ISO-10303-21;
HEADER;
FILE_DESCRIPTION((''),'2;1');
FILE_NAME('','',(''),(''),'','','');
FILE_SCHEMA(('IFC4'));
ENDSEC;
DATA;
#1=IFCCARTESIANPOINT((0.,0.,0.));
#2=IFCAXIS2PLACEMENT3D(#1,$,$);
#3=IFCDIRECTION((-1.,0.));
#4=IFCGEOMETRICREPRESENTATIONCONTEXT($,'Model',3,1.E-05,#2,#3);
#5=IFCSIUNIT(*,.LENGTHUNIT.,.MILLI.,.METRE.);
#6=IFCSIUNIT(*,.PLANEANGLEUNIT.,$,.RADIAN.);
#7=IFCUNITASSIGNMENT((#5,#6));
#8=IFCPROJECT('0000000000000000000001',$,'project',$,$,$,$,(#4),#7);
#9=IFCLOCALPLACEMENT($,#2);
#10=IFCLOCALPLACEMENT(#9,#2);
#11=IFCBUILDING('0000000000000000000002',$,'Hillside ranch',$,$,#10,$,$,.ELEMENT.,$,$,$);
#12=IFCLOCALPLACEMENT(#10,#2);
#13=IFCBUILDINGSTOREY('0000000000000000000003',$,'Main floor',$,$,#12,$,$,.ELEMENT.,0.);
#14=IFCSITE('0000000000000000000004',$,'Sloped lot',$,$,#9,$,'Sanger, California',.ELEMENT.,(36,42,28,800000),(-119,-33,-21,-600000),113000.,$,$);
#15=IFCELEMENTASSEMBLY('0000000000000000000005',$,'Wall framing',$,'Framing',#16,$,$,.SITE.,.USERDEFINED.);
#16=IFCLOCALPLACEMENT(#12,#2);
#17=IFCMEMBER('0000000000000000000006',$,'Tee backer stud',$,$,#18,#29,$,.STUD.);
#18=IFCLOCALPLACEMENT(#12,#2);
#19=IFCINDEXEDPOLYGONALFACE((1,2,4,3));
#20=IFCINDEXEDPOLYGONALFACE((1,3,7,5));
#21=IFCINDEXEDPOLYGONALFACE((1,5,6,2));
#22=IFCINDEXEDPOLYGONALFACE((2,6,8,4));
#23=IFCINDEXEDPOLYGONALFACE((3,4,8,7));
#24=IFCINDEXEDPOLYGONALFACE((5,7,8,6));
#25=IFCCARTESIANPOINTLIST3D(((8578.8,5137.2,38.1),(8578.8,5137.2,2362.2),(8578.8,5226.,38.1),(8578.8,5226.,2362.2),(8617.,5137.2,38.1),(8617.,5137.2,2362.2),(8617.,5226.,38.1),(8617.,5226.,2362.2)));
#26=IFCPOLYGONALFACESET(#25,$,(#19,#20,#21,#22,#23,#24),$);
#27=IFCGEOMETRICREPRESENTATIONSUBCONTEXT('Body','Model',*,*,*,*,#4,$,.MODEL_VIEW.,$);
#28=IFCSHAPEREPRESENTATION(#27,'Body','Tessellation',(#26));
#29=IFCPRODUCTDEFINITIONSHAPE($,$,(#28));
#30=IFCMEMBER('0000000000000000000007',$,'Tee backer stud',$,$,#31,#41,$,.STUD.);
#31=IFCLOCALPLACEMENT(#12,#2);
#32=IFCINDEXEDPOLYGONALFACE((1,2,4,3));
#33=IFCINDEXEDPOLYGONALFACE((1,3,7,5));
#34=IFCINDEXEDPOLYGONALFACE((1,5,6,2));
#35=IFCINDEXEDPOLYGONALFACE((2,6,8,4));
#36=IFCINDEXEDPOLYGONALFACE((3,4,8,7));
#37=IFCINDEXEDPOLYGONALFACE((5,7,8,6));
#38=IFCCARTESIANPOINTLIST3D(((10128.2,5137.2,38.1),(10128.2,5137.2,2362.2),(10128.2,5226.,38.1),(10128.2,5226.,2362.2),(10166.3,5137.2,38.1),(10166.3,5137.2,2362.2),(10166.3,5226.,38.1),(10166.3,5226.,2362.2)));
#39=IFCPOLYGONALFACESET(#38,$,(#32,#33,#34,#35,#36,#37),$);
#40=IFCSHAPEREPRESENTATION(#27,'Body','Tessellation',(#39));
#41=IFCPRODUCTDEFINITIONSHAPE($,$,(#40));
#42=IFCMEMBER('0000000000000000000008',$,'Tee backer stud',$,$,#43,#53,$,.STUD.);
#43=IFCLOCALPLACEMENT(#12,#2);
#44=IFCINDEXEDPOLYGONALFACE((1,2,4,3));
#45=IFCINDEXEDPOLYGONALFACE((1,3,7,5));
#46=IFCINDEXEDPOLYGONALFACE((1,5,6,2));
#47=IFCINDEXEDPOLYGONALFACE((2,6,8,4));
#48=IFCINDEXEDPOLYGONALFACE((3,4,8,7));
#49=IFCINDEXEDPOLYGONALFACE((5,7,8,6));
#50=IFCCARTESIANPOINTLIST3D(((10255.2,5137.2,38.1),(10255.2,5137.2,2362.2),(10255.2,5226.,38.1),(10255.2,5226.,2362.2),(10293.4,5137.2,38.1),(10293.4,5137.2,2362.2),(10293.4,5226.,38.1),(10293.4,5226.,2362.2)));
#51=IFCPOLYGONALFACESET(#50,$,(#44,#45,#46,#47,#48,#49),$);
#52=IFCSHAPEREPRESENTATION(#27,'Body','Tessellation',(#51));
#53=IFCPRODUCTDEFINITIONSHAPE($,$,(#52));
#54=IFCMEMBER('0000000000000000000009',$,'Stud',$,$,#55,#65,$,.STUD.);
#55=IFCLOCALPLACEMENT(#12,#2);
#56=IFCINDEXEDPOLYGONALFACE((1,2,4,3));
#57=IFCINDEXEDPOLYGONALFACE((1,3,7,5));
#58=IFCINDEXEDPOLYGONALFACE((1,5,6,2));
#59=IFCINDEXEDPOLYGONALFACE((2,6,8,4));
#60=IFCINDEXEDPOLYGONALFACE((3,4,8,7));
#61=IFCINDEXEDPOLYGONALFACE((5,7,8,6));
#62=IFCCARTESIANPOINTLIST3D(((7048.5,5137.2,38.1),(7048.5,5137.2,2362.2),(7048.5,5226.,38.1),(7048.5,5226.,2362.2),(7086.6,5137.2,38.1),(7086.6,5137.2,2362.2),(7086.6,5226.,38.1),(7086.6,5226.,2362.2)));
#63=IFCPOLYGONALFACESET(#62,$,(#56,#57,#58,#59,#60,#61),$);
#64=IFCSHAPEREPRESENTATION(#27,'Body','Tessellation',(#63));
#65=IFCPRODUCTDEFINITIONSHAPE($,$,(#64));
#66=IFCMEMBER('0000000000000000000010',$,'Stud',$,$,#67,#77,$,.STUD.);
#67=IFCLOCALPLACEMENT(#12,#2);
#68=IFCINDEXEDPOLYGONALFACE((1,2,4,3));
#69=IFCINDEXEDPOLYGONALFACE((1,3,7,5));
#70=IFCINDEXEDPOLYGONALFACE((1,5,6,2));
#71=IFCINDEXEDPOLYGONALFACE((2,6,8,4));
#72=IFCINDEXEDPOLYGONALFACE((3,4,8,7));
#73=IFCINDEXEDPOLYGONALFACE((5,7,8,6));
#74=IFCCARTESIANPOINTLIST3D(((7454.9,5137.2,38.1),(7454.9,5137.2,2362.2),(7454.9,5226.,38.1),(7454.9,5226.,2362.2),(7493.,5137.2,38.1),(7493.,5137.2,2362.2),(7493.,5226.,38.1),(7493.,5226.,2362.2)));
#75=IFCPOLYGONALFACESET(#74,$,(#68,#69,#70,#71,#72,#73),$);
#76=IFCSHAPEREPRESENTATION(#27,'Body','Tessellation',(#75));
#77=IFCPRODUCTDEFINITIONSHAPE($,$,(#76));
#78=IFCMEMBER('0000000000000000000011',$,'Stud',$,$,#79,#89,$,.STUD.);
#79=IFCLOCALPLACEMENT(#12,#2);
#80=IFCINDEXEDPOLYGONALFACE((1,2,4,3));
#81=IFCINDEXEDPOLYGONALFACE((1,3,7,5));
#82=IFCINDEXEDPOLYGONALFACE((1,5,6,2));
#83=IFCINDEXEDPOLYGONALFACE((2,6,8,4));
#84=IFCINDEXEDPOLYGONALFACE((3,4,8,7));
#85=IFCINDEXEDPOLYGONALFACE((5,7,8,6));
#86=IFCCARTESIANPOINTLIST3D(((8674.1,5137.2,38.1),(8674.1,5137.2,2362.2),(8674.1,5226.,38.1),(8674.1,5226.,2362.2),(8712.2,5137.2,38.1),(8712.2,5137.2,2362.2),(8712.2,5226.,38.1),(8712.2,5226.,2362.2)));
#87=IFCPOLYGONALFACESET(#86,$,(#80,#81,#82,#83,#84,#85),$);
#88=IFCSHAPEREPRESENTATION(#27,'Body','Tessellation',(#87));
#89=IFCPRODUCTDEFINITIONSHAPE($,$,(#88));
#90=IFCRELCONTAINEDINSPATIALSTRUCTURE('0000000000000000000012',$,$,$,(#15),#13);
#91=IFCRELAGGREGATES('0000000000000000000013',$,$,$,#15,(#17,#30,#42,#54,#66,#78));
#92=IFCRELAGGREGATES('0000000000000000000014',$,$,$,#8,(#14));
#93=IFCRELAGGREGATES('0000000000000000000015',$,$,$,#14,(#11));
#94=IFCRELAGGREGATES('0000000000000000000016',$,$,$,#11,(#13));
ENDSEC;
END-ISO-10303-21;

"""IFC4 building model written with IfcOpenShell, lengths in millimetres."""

from ifc_helpers import new_model, si_unit, direction, frame, origin, origin_with_axes, place, context, subcontext, project, spatial, polyline, outline, extrude, element, aggregate, save


model = new_model("IFC4")

# Units and contexts
model_context = context("Model", 3, precision=1e-05, world=origin(), true_north=direction((-1.0, 0.0)))
body_context = subcontext(model_context, "Body", "Model", "MODEL_VIEW")
ifc_project = project(units=[si_unit("LENGTHUNIT", "METRE", prefix="MILLI"), si_unit("PLANEANGLEUNIT", "RADIAN")], contexts=[model_context])

# Site, building, storey
site_placement = place(None, origin())
site = spatial("IfcSite", under=ifc_project, at=site_placement, Name="Sloped lot", LongName="Sanger, California", CompositionType="ELEMENT", RefLatitude=(36, 42, 28, 800000), RefLongitude=(-119, -33, -21, -600000), RefElevation=113000.0)
building_placement = place(site_placement, origin())
building = spatial("IfcBuilding", under=site, at=building_placement, Name="Hillside ranch", CompositionType="ELEMENT")
storey_placement = place(building_placement, origin())
storey = spatial("IfcBuildingStorey", under=building, at=storey_placement, Name="Main floor", CompositionType="ELEMENT", Elevation=0.0)

# Element assembly, members
assembly_placement = place(storey_placement, origin_with_axes())
assembly = element("IfcElementAssembly", 1, at=assembly_placement, inside=storey, Name="Wall framing", ObjectType="Framing", AssemblyPlace="SITE", PredefinedType="USERDEFINED")
member_1_placement = place(storey_placement, origin_with_axes())
member_1 = element("IfcMember", 2, at=member_1_placement, Name="Tee backer stud", PredefinedType="STUD", context=body_context, shape_type="SweptSolid", body=[
    extrude(outline(polyline([(0.0, 0.0), (38.1, 0.0), (38.1, 88.9), (0.0, 88.9), (0.0, 0.0)])), frame((8578.9, 5137.1, 38.1), z_axis=(0.0, 0.0, 1.0), x_axis=(1.0, 0.0, 0.0)), (0.0, 0.0, 1.0), 2324.1),
])
member_2_placement = place(storey_placement, origin_with_axes())
member_2 = element("IfcMember", 3, at=member_2_placement, Name="Tee backer stud", PredefinedType="STUD", context=body_context, shape_type="SweptSolid", body=[
    extrude(outline(polyline([(0.0, 0.0), (38.1, 0.0), (38.1, 88.9), (0.0, 88.9), (0.0, 0.0)])), frame((10128.2, 5137.1, 38.1), z_axis=(0.0, 0.0, 1.0), x_axis=(1.0, 0.0, 0.0)), (0.0, 0.0, 1.0), 2324.1),
])
member_3_placement = place(storey_placement, origin_with_axes())
member_3 = element("IfcMember", 4, at=member_3_placement, Name="Tee backer stud", PredefinedType="STUD", context=body_context, shape_type="SweptSolid", body=[
    extrude(outline(polyline([(0.0, 0.0), (38.1, 0.0), (38.1, 88.9), (0.0, 88.9), (0.0, 0.0)])), frame((10255.2, 5137.1, 38.1), z_axis=(0.0, 0.0, 1.0), x_axis=(1.0, 0.0, 0.0)), (0.0, 0.0, 1.0), 2324.1),
])
member_4_placement = place(storey_placement, origin_with_axes())
member_4 = element("IfcMember", 5, at=member_4_placement, Name="Stud", PredefinedType="STUD", context=body_context, shape_type="SweptSolid", body=[
    extrude(outline(polyline([(0.0, 0.0), (38.1, 0.0), (38.1, 88.9), (0.0, 88.9), (0.0, 0.0)])), frame((7048.5, 5137.1, 38.1), z_axis=(0.0, 0.0, 1.0), x_axis=(1.0, 0.0, 0.0)), (0.0, 0.0, 1.0), 2324.1),
])
member_5_placement = place(storey_placement, origin_with_axes())
member_5 = element("IfcMember", 6, at=member_5_placement, Name="Stud", PredefinedType="STUD", context=body_context, shape_type="SweptSolid", body=[
    extrude(outline(polyline([(0.0, 0.0), (38.1, 0.0), (38.1, 88.9), (0.0, 88.9), (0.0, 0.0)])), frame((7454.9, 5137.1, 38.1), z_axis=(0.0, 0.0, 1.0), x_axis=(1.0, 0.0, 0.0)), (0.0, 0.0, 1.0), 2324.1),
])
member_6_placement = place(storey_placement, origin_with_axes())
member_6 = element("IfcMember", 7, at=member_6_placement, Name="Stud", PredefinedType="STUD", context=body_context, shape_type="SweptSolid", body=[
    extrude(outline(polyline([(0.0, 0.0), (38.1, 0.0), (38.1, 88.9), (0.0, 88.9), (0.0, 0.0)])), frame((8674.1, 5137.1, 38.1), z_axis=(0.0, 0.0, 1.0), x_axis=(1.0, 0.0, 0.0)), (0.0, 0.0, 1.0), 2324.1),
])
aggregate(assembly, [member_1, member_2, member_3, member_4, member_5, member_6])

save(model, "model.ifc")
